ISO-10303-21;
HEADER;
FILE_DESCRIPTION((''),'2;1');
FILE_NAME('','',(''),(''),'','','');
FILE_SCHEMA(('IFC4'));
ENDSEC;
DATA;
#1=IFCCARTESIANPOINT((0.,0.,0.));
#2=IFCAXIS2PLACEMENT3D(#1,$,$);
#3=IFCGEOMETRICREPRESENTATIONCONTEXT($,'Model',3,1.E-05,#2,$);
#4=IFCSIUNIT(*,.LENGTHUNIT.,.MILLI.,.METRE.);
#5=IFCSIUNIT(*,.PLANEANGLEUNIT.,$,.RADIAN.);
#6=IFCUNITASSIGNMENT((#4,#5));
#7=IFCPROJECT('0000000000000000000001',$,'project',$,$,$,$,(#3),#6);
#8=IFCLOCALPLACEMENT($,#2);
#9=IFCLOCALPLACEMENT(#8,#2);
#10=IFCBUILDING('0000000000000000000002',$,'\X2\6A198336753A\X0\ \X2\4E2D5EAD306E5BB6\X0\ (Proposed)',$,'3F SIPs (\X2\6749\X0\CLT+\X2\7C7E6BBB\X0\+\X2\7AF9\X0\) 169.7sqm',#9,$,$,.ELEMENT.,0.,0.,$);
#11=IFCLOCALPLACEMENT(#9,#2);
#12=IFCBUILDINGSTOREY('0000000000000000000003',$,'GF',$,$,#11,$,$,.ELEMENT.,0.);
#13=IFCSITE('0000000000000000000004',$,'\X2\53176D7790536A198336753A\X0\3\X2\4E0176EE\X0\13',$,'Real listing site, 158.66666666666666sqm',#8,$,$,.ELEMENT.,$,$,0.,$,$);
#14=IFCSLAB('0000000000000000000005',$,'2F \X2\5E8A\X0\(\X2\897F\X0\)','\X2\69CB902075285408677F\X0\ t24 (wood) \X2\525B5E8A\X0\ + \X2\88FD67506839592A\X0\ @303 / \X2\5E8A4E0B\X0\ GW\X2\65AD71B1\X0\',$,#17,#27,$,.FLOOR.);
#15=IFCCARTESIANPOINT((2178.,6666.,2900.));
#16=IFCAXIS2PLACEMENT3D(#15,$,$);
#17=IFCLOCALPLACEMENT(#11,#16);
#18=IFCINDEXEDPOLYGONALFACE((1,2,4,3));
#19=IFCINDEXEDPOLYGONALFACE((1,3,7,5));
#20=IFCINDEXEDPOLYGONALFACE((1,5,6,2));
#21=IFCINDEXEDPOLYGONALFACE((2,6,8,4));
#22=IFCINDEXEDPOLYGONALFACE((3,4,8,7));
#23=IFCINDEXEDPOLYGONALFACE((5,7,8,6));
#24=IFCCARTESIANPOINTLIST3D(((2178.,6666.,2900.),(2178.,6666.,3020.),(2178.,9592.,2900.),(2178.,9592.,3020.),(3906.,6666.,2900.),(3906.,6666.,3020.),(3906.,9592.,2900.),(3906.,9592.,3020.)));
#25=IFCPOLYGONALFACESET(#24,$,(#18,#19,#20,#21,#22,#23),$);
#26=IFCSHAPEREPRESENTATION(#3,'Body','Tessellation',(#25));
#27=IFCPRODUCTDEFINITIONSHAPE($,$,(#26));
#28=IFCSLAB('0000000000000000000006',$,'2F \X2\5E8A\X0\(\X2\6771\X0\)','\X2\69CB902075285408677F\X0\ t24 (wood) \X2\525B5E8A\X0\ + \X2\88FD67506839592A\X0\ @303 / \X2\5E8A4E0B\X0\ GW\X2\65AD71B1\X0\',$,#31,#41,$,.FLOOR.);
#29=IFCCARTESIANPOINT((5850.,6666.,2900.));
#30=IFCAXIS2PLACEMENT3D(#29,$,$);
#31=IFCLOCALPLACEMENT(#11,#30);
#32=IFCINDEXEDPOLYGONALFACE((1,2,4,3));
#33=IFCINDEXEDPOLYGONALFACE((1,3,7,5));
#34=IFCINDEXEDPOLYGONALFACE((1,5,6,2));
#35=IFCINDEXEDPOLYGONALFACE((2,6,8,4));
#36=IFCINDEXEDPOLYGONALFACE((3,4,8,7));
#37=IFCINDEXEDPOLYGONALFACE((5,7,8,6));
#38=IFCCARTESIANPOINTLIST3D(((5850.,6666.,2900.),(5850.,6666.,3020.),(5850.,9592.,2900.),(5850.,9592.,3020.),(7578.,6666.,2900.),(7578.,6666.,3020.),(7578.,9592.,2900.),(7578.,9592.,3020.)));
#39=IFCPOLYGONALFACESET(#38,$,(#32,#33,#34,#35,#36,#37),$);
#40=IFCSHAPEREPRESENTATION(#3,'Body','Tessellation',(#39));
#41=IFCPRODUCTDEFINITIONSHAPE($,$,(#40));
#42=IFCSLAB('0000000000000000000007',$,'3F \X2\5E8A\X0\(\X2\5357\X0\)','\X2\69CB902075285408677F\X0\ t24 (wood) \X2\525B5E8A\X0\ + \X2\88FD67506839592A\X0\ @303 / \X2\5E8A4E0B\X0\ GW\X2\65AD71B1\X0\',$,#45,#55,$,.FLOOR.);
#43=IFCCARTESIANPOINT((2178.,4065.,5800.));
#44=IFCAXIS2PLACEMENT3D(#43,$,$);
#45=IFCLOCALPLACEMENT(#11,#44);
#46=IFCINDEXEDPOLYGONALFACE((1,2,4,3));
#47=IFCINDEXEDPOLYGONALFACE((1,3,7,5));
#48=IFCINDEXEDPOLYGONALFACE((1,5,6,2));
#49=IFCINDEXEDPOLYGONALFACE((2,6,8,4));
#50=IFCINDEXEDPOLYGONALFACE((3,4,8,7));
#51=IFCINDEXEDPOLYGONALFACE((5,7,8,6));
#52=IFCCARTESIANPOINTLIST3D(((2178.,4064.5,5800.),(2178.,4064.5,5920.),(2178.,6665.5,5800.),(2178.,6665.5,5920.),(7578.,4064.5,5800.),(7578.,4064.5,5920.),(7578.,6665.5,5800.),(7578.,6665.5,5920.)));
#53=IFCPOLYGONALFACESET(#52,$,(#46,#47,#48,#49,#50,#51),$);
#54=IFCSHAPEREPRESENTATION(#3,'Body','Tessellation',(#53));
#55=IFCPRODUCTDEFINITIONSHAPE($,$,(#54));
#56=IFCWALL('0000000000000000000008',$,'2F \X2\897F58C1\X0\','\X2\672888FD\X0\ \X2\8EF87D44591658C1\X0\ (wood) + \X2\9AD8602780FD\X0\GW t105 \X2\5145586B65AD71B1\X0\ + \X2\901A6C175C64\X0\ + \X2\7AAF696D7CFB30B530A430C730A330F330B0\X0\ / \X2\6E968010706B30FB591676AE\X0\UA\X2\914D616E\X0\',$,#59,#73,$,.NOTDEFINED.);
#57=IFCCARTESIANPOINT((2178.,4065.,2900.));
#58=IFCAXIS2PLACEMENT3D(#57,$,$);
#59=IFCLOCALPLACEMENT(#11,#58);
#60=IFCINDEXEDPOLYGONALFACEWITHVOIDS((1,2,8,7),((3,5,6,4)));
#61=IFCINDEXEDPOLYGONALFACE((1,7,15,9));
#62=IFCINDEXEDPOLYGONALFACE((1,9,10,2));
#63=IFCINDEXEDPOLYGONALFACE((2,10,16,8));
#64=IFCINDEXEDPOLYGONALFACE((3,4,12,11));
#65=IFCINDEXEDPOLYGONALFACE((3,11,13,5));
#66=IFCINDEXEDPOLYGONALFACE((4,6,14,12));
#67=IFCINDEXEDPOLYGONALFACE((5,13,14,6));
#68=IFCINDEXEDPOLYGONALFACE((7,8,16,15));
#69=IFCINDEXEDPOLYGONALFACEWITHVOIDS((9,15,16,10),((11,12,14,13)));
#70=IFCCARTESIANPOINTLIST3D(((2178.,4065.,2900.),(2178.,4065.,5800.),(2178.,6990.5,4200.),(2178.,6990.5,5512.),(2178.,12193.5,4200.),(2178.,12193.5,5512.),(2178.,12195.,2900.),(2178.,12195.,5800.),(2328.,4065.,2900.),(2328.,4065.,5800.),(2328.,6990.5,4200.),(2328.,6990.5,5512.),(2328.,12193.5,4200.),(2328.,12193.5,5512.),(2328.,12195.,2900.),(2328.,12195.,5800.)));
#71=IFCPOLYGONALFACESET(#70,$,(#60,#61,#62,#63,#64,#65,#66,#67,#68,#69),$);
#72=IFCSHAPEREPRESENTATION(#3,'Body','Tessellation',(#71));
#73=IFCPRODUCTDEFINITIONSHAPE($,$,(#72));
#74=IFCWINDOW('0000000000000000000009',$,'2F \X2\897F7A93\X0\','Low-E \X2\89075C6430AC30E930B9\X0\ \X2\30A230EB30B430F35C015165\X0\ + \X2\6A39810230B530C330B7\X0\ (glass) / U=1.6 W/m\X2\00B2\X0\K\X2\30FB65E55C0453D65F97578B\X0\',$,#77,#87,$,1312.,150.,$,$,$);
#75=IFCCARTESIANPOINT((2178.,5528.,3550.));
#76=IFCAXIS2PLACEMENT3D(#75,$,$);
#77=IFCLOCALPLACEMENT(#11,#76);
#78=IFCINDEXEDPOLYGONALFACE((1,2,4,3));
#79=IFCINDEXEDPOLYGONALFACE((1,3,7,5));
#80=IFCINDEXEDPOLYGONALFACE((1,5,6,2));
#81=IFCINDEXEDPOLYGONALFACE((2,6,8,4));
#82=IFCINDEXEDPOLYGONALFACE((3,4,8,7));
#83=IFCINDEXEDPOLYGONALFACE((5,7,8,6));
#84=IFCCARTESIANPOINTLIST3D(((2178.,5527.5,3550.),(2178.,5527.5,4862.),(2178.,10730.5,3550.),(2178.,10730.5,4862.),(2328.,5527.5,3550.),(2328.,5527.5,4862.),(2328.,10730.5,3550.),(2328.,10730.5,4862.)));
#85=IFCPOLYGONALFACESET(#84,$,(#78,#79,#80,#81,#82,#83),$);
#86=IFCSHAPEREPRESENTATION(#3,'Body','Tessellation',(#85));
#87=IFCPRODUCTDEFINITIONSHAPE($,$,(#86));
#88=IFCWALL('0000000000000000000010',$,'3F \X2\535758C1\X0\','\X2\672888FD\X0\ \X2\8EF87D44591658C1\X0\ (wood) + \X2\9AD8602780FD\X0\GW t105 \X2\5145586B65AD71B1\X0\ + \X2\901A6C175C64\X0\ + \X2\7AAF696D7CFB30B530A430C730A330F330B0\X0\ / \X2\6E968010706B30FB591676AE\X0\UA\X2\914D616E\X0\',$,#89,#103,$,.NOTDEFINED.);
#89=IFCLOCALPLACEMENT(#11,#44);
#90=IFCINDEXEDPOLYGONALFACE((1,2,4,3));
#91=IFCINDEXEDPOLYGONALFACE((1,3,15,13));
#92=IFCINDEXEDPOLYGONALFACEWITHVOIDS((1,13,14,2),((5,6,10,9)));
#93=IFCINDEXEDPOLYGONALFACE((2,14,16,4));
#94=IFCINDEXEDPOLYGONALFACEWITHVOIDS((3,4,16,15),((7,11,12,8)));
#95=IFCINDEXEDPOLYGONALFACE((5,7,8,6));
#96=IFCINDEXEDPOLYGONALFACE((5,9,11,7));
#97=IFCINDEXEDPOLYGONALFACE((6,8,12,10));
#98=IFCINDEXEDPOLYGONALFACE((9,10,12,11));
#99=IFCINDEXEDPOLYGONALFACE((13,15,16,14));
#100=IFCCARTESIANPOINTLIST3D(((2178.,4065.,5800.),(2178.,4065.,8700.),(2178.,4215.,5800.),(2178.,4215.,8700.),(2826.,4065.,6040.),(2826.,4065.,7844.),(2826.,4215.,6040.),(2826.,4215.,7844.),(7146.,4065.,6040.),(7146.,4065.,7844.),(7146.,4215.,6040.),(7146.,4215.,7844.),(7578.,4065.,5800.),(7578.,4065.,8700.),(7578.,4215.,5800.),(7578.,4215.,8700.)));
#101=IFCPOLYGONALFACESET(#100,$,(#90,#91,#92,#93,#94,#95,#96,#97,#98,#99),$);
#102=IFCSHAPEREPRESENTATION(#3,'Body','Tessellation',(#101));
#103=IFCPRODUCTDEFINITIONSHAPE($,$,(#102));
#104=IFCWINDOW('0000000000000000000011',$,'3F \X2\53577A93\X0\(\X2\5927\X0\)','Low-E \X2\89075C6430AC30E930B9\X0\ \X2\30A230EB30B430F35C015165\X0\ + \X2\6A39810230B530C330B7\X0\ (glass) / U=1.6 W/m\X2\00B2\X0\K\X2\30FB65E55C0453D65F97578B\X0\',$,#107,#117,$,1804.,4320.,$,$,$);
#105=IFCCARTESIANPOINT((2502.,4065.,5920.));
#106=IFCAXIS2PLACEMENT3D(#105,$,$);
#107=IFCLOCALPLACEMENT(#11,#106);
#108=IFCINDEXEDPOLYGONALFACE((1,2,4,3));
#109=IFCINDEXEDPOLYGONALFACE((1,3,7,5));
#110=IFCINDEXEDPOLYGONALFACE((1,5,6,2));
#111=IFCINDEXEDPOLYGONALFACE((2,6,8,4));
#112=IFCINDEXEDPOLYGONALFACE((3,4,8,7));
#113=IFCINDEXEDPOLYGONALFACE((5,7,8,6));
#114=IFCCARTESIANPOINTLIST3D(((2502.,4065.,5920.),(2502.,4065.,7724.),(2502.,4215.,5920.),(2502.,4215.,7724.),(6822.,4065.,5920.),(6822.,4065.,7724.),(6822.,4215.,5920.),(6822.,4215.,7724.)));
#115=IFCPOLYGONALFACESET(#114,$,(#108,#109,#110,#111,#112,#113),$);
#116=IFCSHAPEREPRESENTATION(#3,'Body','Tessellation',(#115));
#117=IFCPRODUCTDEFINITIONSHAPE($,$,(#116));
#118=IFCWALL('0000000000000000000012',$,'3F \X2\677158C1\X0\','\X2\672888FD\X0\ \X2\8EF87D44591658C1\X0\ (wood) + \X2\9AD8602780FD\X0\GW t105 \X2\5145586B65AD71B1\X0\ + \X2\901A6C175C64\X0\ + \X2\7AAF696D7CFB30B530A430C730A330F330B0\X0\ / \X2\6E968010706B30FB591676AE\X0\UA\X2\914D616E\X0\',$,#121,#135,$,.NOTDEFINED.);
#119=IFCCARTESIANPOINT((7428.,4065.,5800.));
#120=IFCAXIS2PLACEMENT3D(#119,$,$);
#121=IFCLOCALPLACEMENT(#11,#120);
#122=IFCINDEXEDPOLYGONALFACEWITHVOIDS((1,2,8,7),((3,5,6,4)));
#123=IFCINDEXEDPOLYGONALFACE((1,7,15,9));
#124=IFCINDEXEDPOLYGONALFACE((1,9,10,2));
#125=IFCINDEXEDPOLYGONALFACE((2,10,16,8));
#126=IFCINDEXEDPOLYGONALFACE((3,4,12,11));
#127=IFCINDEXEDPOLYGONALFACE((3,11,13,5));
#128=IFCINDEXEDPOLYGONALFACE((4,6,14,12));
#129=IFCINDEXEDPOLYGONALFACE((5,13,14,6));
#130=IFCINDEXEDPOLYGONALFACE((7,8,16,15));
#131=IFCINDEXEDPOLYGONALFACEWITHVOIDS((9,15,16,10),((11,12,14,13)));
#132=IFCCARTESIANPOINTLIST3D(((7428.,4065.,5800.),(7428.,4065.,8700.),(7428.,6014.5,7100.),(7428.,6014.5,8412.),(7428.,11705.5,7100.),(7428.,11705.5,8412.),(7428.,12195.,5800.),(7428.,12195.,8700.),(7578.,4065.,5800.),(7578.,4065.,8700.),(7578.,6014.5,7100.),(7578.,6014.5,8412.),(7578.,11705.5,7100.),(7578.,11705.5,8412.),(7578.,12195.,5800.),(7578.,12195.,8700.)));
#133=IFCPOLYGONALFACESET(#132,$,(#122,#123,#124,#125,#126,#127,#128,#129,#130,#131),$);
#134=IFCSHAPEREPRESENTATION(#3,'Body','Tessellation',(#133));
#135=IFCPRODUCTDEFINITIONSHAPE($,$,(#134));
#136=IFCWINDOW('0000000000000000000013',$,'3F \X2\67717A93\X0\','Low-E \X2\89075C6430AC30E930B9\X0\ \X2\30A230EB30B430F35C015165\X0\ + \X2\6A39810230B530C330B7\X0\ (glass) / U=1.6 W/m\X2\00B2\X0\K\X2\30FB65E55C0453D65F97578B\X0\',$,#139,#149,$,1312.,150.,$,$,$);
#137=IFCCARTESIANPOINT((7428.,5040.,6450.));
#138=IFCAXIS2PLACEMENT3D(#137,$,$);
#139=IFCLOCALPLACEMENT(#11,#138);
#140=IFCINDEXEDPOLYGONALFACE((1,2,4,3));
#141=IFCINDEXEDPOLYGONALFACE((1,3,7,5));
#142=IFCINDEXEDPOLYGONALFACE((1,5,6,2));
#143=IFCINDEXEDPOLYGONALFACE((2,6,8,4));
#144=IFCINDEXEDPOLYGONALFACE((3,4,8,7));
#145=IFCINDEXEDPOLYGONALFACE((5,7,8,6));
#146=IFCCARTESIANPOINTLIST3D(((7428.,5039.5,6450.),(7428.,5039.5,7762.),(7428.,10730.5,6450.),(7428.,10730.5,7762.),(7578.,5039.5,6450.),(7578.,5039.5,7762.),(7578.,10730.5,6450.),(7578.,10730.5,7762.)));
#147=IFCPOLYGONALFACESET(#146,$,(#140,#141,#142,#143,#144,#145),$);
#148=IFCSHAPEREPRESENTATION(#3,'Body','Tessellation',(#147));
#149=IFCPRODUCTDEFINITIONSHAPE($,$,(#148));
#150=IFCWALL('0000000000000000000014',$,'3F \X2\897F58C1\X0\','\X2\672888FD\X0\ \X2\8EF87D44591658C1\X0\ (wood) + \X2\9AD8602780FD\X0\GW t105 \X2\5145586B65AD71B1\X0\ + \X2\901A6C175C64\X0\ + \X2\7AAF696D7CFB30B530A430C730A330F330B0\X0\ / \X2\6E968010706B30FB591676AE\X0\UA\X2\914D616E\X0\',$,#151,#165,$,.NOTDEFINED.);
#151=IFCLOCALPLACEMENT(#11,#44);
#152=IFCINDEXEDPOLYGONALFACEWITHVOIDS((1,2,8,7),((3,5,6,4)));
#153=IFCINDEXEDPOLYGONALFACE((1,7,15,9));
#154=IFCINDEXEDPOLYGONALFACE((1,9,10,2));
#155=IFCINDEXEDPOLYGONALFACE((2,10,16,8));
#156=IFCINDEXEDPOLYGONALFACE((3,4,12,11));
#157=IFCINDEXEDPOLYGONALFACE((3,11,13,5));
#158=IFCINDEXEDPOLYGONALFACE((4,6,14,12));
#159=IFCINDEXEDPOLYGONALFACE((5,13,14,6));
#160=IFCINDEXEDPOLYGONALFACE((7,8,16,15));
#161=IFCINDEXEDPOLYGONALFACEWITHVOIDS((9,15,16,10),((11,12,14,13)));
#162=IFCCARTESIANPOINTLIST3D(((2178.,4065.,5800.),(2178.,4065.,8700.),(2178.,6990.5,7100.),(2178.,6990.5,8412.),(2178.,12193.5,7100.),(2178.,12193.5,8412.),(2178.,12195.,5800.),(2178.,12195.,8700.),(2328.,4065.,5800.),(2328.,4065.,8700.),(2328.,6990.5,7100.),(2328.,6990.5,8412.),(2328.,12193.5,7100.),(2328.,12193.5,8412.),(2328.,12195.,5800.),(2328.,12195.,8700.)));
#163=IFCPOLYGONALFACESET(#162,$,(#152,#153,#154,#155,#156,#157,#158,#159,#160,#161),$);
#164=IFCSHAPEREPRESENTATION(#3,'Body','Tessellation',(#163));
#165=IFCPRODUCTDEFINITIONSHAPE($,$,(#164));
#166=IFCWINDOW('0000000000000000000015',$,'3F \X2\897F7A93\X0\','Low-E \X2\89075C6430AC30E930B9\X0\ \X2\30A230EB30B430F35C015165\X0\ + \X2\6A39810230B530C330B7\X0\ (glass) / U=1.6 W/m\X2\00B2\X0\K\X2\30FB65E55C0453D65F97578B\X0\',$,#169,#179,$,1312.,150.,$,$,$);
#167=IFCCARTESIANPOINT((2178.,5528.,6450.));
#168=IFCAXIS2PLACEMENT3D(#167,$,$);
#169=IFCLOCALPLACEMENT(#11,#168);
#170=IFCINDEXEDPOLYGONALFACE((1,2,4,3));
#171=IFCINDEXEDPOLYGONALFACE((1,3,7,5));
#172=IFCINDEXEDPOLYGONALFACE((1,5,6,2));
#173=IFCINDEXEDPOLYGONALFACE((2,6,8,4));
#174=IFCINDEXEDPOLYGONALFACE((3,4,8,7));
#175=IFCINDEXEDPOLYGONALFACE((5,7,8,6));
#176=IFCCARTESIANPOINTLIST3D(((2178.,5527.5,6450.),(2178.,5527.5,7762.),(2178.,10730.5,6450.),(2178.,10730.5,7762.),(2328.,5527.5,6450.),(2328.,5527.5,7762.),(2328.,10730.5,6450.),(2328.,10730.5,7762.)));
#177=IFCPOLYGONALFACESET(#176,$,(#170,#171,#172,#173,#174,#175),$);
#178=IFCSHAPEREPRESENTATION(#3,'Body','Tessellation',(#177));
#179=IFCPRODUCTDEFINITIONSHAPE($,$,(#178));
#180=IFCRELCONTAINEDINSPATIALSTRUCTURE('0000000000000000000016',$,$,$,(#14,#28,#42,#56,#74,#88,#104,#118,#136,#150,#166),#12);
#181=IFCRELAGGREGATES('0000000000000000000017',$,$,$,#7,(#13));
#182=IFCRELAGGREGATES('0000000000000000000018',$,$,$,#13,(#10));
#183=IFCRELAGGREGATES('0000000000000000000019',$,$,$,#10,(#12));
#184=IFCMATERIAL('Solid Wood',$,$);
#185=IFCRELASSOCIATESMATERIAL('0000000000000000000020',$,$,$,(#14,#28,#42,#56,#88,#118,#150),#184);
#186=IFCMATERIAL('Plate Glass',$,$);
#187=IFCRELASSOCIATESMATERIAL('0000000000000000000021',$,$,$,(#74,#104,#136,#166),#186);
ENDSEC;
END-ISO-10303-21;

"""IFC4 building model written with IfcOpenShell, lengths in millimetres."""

from ifc_helpers import new_model, si_unit, frame, frame_2d, origin, place, context, project, spatial, rectangle, extrude, material, element, fill, save


model = new_model("IFC4")

# Units and contexts
model_context = context("Model", 3, precision=1e-05, world=origin())
ifc_project = project(units=[si_unit("LENGTHUNIT", "METRE", prefix="MILLI"), si_unit("PLANEANGLEUNIT", "RADIAN")], contexts=[model_context])

# Site, building, storey
site_placement = place(None, origin())
site = spatial("IfcSite", under=ifc_project, at=site_placement, Name="北海道標茶町3丁目13", ObjectType="Real listing site, 158.66666666666666sqm", CompositionType="ELEMENT", RefElevation=0.0)
building_placement = place(site_placement, origin())
building = spatial("IfcBuilding", under=site, at=building_placement, Name="標茶町 中庭の家 (Proposed)", ObjectType="3F SIPs (杉CLT+籾殻+竹) 169.7sqm", CompositionType="ELEMENT", ElevationOfRefHeight=0.0, ElevationOfTerrain=0.0)
storey_placement = place(building_placement, origin())
storey = spatial("IfcBuildingStorey", under=building, at=storey_placement, Name="GF", CompositionType="ELEMENT", Elevation=0.0)

# Slabs
ifc_material_1 = material(Name="Solid Wood")
slab_1_placement = place(storey_placement, frame((2178.0, 6666.0, 2900.0)))
element("IfcSlab", 1, at=slab_1_placement, inside=storey, material=ifc_material_1, Name="2F 床(西)", Description="構造用合板 t24 (wood) 剛床 + 製材根太 @303 / 床下 GW断熱", PredefinedType="FLOOR", context=model_context, shape_type="SweptSolid", body=[
    extrude(rectangle(XDim=1728.0, YDim=2926.0, at=frame_2d((864.0, 1463.0))), frame((2178.0, 6666.0, 2900.0)), (0.0, 0.0, 1.0), 120.0),
])
slab_2_placement = place(storey_placement, frame((5850.0, 6666.0, 2900.0)))
element("IfcSlab", 2, at=slab_2_placement, inside=storey, material=ifc_material_1, Name="2F 床(東)", Description="構造用合板 t24 (wood) 剛床 + 製材根太 @303 / 床下 GW断熱", PredefinedType="FLOOR", context=model_context, shape_type="SweptSolid", body=[
    extrude(rectangle(XDim=1728.0, YDim=2926.0, at=frame_2d((864.0, 1463.0))), frame((5850.0, 6666.0, 2900.0)), (0.0, 0.0, 1.0), 120.0),
])
slab_3_placement = place(storey_placement, frame((2178.0, 4065.0, 5800.0)))
element("IfcSlab", 3, at=slab_3_placement, inside=storey, material=ifc_material_1, Name="3F 床(南)", Description="構造用合板 t24 (wood) 剛床 + 製材根太 @303 / 床下 GW断熱", PredefinedType="FLOOR", context=model_context, shape_type="SweptSolid", body=[
    extrude(rectangle(XDim=5400.0, YDim=2601.0, at=frame_2d((2700.0, 1300.0))), frame((2178.0, 4065.0, 5800.0)), (0.0, 0.0, 1.0), 120.0),
])

# Walls, openings, windows
wall_1_placement = place(storey_placement, frame((2178.0, 4065.0, 2900.0)))
wall_1 = element("IfcWall", 4, at=wall_1_placement, inside=storey, material=ifc_material_1, Name="2F 西壁", Description="木製 軸組外壁 (wood) + 高性能GW t105 充填断熱 + 通気層 + 窯業系サイディング / 準耐火・外皮UA配慮", PredefinedType="NOTDEFINED", context=model_context, shape_type="SweptSolid", body=[
    extrude(rectangle(XDim=150.0, YDim=8130.0, at=frame_2d((75.0, 4065.0))), frame((2178.0, 4065.0, 2900.0)), (0.0, 0.0, 1.0), 2900.0),
])
opening_1_placement = place(storey_placement, frame((2178.0, 5528.0, 3550.0)))
opening_1 = element("IfcOpeningElement", 5, at=opening_1_placement, cuts=wall_1, PredefinedType="NOTDEFINED", context=model_context, shape_type="SweptSolid", body=[
    extrude(rectangle(XDim=150.0, YDim=5203.0, at=frame_2d((75.0, 2601.0))), frame((2178.0, 5528.0, 3550.0)), (0.0, 0.0, 1.0), 1312.0),
])
ifc_material_2 = material(Name="Plate Glass")
window_1_placement = place(storey_placement, frame((2178.0, 5528.0, 3550.0)))
window_1 = element("IfcWindow", 6, at=window_1_placement, inside=storey, material=ifc_material_2, Name="2F 西窓", Description="Low-E 複層ガラス アルゴン封入 + 樹脂サッシ (glass) / U=1.6 W/m²K・日射取得型", OverallHeight=1312.0, OverallWidth=150.0, context=model_context, shape_type="SweptSolid", body=[
    extrude(rectangle(XDim=150.0, YDim=5203.0, at=frame_2d((75.0, 2601.0))), frame((2178.0, 5528.0, 3550.0)), (0.0, 0.0, 1.0), 1312.0),
])
fill(opening_1, window_1)
wall_2_placement = place(storey_placement, frame((2178.0, 4065.0, 5800.0)))
wall_2 = element("IfcWall", 7, at=wall_2_placement, inside=storey, material=ifc_material_1, Name="3F 南壁", Description="木製 軸組外壁 (wood) + 高性能GW t105 充填断熱 + 通気層 + 窯業系サイディング / 準耐火・外皮UA配慮", PredefinedType="NOTDEFINED", context=model_context, shape_type="SweptSolid", body=[
    extrude(rectangle(XDim=5400.0, YDim=150.0, at=frame_2d((2700.0, 75.0))), frame((2178.0, 4065.0, 5800.0)), (0.0, 0.0, 1.0), 2900.0),
])
opening_2_placement = place(storey_placement, frame((2502.0, 4065.0, 5920.0)))
opening_2 = element("IfcOpeningElement", 8, at=opening_2_placement, cuts=wall_2, PredefinedType="NOTDEFINED", context=model_context, shape_type="SweptSolid", body=[
    extrude(rectangle(XDim=4320.0, YDim=150.0, at=frame_2d((2160.0, 75.0))), frame((2502.0, 4065.0, 5920.0)), (0.0, 0.0, 1.0), 1804.0),
])
window_2_placement = place(storey_placement, frame((2502.0, 4065.0, 5920.0)))
window_2 = element("IfcWindow", 9, at=window_2_placement, inside=storey, material=ifc_material_2, Name="3F 南窓(大)", Description="Low-E 複層ガラス アルゴン封入 + 樹脂サッシ (glass) / U=1.6 W/m²K・日射取得型", OverallHeight=1804.0, OverallWidth=4320.0, context=model_context, shape_type="SweptSolid", body=[
    extrude(rectangle(XDim=4320.0, YDim=150.0, at=frame_2d((2160.0, 75.0))), frame((2502.0, 4065.0, 5920.0)), (0.0, 0.0, 1.0), 1804.0),
])
fill(opening_2, window_2)
wall_3_placement = place(storey_placement, frame((7428.0, 4065.0, 5800.0)))
wall_3 = element("IfcWall", 10, at=wall_3_placement, inside=storey, material=ifc_material_1, Name="3F 東壁", Description="木製 軸組外壁 (wood) + 高性能GW t105 充填断熱 + 通気層 + 窯業系サイディング / 準耐火・外皮UA配慮", PredefinedType="NOTDEFINED", context=model_context, shape_type="SweptSolid", body=[
    extrude(rectangle(XDim=150.0, YDim=8130.0, at=frame_2d((75.0, 4065.0))), frame((7428.0, 4065.0, 5800.0)), (0.0, 0.0, 1.0), 2900.0),
])
opening_3_placement = place(storey_placement, frame((7428.0, 5040.0, 6450.0)))
opening_3 = element("IfcOpeningElement", 11, at=opening_3_placement, cuts=wall_3, PredefinedType="NOTDEFINED", context=model_context, shape_type="SweptSolid", body=[
    extrude(rectangle(XDim=150.0, YDim=5691.0, at=frame_2d((75.0, 2845.0))), frame((7428.0, 5040.0, 6450.0)), (0.0, 0.0, 1.0), 1312.0),
])
window_3_placement = place(storey_placement, frame((7428.0, 5040.0, 6450.0)))
window_3 = element("IfcWindow", 12, at=window_3_placement, inside=storey, material=ifc_material_2, Name="3F 東窓", Description="Low-E 複層ガラス アルゴン封入 + 樹脂サッシ (glass) / U=1.6 W/m²K・日射取得型", OverallHeight=1312.0, OverallWidth=150.0, context=model_context, shape_type="SweptSolid", body=[
    extrude(rectangle(XDim=150.0, YDim=5691.0, at=frame_2d((75.0, 2845.0))), frame((7428.0, 5040.0, 6450.0)), (0.0, 0.0, 1.0), 1312.0),
])
fill(opening_3, window_3)
wall_4_placement = place(storey_placement, frame((2178.0, 4065.0, 5800.0)))
wall_4 = element("IfcWall", 13, at=wall_4_placement, inside=storey, material=ifc_material_1, Name="3F 西壁", Description="木製 軸組外壁 (wood) + 高性能GW t105 充填断熱 + 通気層 + 窯業系サイディング / 準耐火・外皮UA配慮", PredefinedType="NOTDEFINED", context=model_context, shape_type="SweptSolid", body=[
    extrude(rectangle(XDim=150.0, YDim=8130.0, at=frame_2d((75.0, 4065.0))), frame((2178.0, 4065.0, 5800.0)), (0.0, 0.0, 1.0), 2900.0),
])
opening_4_placement = place(storey_placement, frame((2178.0, 5528.0, 6450.0)))
opening_4 = element("IfcOpeningElement", 14, at=opening_4_placement, cuts=wall_4, PredefinedType="NOTDEFINED", context=model_context, shape_type="SweptSolid", body=[
    extrude(rectangle(XDim=150.0, YDim=5203.0, at=frame_2d((75.0, 2601.0))), frame((2178.0, 5528.0, 6450.0)), (0.0, 0.0, 1.0), 1312.0),
])
window_4_placement = place(storey_placement, frame((2178.0, 5528.0, 6450.0)))
window_4 = element("IfcWindow", 15, at=window_4_placement, inside=storey, material=ifc_material_2, Name="3F 西窓", Description="Low-E 複層ガラス アルゴン封入 + 樹脂サッシ (glass) / U=1.6 W/m²K・日射取得型", OverallHeight=1312.0, OverallWidth=150.0, context=model_context, shape_type="SweptSolid", body=[
    extrude(rectangle(XDim=150.0, YDim=5203.0, at=frame_2d((75.0, 2601.0))), frame((2178.0, 5528.0, 6450.0)), (0.0, 0.0, 1.0), 1312.0),
])
fill(opening_4, window_4)

save(model, "model.ifc")
